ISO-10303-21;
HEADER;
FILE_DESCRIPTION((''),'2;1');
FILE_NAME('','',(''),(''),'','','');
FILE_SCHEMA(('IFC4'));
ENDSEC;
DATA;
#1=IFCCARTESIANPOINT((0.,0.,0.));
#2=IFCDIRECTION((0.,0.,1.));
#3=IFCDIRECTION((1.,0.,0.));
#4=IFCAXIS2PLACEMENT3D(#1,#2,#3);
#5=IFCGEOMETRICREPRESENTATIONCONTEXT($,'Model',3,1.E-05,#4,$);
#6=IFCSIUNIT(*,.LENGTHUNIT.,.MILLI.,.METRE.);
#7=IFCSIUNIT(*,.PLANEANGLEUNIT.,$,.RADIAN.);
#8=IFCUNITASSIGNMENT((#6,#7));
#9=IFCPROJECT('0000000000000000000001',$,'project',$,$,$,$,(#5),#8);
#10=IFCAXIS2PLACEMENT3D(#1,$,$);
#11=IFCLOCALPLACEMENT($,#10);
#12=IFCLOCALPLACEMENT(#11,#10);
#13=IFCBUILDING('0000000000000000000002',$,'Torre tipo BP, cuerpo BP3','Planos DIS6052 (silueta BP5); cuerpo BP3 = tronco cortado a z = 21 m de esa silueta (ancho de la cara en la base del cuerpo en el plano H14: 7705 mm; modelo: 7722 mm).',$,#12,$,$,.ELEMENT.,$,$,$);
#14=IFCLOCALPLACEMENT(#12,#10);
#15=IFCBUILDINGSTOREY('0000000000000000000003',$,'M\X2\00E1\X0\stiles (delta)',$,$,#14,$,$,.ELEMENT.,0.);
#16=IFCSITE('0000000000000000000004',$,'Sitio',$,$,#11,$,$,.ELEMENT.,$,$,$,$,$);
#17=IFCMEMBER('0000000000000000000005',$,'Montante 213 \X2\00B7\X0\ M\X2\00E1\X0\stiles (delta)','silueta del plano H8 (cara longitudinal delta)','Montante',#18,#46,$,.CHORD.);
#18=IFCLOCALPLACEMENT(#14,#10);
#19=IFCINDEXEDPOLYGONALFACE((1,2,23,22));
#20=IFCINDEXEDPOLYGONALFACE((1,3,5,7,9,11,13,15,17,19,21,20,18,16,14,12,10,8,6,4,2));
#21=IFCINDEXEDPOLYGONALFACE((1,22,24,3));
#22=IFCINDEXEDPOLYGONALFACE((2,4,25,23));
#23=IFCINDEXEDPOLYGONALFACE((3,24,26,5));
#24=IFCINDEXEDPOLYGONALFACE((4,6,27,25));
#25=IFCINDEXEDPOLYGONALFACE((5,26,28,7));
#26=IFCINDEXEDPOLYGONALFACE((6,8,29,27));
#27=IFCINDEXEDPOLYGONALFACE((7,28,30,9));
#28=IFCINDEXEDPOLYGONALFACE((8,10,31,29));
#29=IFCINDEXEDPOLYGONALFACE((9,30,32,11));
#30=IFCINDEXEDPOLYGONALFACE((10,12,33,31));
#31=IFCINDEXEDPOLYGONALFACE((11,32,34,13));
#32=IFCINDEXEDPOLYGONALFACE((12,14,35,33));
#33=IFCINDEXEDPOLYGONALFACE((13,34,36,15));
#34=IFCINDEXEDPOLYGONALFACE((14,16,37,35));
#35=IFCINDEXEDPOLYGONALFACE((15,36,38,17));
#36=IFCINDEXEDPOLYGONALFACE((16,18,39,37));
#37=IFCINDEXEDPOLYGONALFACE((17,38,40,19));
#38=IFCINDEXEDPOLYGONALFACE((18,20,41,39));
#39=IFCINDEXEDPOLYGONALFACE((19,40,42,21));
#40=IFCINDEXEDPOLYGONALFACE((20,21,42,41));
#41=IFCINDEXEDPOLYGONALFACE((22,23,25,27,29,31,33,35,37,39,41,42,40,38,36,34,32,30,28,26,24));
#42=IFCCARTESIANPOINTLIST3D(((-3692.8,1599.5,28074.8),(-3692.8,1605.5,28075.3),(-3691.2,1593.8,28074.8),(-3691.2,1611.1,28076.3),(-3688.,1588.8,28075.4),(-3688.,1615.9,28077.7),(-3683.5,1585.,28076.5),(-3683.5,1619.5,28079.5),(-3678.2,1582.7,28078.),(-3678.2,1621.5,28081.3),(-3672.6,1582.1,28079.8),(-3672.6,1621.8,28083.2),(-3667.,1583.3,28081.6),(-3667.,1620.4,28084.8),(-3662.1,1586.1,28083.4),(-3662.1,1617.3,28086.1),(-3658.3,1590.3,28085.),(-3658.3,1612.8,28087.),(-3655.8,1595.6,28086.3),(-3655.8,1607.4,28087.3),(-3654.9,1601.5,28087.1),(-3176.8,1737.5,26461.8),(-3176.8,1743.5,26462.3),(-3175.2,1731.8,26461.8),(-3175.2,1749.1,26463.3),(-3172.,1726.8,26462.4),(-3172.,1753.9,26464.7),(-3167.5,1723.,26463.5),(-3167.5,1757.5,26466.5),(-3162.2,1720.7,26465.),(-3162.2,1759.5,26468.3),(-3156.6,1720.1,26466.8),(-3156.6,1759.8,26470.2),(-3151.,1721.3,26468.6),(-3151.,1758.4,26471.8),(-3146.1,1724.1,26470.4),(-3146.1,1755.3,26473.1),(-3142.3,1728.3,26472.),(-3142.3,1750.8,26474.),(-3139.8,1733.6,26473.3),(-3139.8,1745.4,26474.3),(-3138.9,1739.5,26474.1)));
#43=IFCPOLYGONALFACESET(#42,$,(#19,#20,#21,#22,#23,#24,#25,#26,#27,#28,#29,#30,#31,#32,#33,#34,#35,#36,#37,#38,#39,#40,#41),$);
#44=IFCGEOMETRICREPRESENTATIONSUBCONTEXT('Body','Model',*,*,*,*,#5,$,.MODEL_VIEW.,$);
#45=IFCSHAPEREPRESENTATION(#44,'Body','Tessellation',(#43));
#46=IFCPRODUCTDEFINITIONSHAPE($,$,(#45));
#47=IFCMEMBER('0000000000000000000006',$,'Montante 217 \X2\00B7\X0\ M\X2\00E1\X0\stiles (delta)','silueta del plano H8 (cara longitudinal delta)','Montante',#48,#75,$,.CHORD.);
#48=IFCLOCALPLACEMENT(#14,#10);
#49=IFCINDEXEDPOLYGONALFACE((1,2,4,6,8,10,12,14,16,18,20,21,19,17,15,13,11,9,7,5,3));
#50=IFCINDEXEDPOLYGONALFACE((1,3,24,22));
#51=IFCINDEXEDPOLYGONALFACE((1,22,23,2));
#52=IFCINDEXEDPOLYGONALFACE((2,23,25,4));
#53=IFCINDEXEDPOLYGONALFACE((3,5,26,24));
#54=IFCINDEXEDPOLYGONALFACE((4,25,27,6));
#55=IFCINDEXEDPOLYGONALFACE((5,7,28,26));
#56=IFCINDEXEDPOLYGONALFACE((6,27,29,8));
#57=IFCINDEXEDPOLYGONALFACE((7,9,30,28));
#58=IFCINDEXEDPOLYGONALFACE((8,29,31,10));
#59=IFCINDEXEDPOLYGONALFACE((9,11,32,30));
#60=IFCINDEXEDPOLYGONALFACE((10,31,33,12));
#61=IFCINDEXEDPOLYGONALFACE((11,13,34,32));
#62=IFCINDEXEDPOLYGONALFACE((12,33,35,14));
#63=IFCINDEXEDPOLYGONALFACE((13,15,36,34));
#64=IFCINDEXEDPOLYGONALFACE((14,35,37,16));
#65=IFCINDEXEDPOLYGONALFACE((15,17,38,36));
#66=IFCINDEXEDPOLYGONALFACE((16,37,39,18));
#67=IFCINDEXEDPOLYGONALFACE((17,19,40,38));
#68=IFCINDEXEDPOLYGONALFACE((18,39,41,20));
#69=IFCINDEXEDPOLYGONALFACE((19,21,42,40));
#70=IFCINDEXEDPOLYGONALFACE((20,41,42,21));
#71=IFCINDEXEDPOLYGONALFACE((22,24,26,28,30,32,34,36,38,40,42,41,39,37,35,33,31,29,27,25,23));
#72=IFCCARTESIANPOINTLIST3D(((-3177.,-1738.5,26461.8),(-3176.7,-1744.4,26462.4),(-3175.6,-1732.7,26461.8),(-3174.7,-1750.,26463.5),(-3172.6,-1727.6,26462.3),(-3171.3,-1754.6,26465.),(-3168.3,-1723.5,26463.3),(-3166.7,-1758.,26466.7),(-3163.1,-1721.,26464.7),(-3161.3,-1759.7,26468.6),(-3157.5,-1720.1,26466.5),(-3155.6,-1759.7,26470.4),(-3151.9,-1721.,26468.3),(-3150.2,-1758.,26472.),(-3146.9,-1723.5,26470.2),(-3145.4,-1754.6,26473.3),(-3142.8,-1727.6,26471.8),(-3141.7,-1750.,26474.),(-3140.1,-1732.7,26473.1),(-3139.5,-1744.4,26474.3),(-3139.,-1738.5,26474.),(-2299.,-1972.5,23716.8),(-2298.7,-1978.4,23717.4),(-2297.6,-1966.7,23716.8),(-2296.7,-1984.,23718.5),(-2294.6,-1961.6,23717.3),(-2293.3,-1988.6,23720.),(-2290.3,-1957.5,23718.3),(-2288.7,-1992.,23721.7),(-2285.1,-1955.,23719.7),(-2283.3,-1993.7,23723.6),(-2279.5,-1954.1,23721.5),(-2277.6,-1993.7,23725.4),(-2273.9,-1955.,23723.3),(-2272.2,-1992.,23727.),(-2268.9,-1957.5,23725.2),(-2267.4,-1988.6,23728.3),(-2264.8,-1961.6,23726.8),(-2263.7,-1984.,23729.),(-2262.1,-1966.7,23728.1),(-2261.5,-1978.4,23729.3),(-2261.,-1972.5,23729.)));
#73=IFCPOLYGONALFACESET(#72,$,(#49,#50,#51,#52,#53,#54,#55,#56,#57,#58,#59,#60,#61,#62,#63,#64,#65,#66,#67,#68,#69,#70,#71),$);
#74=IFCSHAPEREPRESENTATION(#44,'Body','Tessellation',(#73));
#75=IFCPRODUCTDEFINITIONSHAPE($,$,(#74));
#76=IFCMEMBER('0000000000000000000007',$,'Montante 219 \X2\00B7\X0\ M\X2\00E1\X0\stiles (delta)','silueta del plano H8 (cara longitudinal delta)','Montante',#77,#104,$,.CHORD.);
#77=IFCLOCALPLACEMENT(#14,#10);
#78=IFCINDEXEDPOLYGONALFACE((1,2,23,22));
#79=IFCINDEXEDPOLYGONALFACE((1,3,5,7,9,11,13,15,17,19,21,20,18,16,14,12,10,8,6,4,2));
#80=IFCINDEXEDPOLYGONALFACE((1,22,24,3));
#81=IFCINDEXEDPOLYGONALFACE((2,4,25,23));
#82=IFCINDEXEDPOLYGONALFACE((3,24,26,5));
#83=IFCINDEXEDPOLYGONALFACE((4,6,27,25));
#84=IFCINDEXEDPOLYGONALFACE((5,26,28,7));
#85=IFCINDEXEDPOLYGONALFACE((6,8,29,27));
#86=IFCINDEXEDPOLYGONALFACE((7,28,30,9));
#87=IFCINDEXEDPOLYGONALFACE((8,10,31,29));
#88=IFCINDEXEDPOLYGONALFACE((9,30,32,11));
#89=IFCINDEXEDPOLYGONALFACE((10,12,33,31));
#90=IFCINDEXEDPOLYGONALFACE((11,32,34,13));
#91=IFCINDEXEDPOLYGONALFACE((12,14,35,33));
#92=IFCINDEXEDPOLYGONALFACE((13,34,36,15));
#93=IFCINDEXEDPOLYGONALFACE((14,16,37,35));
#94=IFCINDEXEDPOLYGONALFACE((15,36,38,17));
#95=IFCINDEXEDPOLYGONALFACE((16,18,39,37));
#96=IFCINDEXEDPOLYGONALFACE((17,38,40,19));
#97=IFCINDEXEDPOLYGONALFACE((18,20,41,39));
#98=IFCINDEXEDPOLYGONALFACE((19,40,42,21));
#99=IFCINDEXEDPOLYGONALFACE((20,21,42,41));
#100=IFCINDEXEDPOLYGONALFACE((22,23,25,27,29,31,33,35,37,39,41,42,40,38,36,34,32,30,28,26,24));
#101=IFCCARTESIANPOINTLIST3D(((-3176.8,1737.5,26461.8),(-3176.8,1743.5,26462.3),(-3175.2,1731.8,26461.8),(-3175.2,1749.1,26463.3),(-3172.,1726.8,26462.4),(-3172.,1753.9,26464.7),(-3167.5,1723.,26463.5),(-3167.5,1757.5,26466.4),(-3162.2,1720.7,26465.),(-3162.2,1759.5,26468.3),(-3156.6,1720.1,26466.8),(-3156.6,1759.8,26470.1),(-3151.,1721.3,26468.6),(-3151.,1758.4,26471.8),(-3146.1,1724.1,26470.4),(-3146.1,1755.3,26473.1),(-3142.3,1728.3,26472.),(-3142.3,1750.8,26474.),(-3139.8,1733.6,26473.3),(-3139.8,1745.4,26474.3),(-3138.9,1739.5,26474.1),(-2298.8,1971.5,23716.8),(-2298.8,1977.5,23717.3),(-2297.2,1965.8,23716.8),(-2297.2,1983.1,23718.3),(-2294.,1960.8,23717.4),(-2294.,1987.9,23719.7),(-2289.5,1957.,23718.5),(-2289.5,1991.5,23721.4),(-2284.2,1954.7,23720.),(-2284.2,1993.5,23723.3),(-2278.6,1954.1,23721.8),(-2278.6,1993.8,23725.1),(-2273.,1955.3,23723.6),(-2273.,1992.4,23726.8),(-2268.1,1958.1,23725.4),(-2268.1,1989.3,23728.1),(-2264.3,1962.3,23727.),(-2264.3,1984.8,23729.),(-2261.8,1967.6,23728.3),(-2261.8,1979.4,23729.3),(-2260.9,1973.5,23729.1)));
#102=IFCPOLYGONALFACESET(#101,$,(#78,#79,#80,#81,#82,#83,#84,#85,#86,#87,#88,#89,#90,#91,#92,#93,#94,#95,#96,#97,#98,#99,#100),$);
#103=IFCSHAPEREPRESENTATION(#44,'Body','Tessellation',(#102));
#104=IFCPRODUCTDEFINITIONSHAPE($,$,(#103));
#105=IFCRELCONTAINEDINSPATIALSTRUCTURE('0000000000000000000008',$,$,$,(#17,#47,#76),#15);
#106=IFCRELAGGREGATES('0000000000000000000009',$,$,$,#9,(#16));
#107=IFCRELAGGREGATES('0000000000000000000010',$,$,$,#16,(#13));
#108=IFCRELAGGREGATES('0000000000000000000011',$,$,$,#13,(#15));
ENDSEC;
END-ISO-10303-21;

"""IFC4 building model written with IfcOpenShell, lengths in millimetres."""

from ifc_helpers import new_model, si_unit, frame, origin, origin_with_axes, place, context, subcontext, project, spatial, circle, extrude, element, save


model = new_model("IFC4")

# Units and contexts
model_context = context("Model", 3, precision=1e-05, world=origin_with_axes())
body_context = subcontext(model_context, "Body", "Model", "MODEL_VIEW")
ifc_project = project(units=[si_unit("LENGTHUNIT", "METRE", prefix="MILLI"), si_unit("PLANEANGLEUNIT", "RADIAN")], contexts=[model_context])

# Site, building, storey
site_placement = place(None, origin())
site = spatial("IfcSite", under=ifc_project, at=site_placement, Name="Sitio", CompositionType="ELEMENT")
building_placement = place(site_placement, origin())
building = spatial("IfcBuilding", under=site, at=building_placement, Name="Torre tipo BP, cuerpo BP3", Description="Planos DIS6052 (silueta BP5); cuerpo BP3 = tronco cortado a z = 21 m de esa silueta (ancho de la cara en la base del cuerpo en el plano H14: 7705 mm; modelo: 7722 mm).", CompositionType="ELEMENT")
storey_placement = place(building_placement, origin())
storey = spatial("IfcBuildingStorey", under=building, at=storey_placement, Name="Mástiles (delta)", CompositionType="ELEMENT", Elevation=0.0)

# Members
for number, where, z_axis, x_axis, name in (
    (1, (-3674.0, 1602.0, 28081.0), (0.303683, 0.081218, -0.949305), (0.952773, -0.025887, 0.302578), "Montante 213 · Mástiles (delta)"),
):
    element("IfcMember", number, at=place(storey_placement, frame(where, z_axis=z_axis, x_axis=x_axis)), inside=storey, Name=name, Description="silueta del plano H8 (cara longitudinal delta)", ObjectType="Montante", PredefinedType="CHORD", context=body_context, shape_type="SweptSolid", body=[
        extrude(circle(Radius=20.0), None, (0.0, 0.0, 1.0), 1699.1),
    ])
for number, where, z_axis, x_axis, name in (
    (2, (-3158.0, -1740.0, 26468.0), (0.303651, -0.080927, -0.94934), (0.024655, 0.99672, -0.07708), "Montante 217 · Mástiles (delta)"),
    (3, (-3158.0, 1740.0, 26468.0), (0.303651, 0.080927, -0.94934), (0.952783, -0.025791, 0.302553), "Montante 219 · Mástiles (delta)"),
):
    element("IfcMember", number, at=place(storey_placement, frame(where, z_axis=z_axis, x_axis=x_axis)), inside=storey, Name=name, Description="silueta del plano H8 (cara longitudinal delta)", ObjectType="Montante", PredefinedType="CHORD", context=body_context, shape_type="SweptSolid", body=[
        extrude(circle(Radius=20.0), None, (0.0, 0.0, 1.0), 2891.5),
    ])

save(model, "model.ifc")
